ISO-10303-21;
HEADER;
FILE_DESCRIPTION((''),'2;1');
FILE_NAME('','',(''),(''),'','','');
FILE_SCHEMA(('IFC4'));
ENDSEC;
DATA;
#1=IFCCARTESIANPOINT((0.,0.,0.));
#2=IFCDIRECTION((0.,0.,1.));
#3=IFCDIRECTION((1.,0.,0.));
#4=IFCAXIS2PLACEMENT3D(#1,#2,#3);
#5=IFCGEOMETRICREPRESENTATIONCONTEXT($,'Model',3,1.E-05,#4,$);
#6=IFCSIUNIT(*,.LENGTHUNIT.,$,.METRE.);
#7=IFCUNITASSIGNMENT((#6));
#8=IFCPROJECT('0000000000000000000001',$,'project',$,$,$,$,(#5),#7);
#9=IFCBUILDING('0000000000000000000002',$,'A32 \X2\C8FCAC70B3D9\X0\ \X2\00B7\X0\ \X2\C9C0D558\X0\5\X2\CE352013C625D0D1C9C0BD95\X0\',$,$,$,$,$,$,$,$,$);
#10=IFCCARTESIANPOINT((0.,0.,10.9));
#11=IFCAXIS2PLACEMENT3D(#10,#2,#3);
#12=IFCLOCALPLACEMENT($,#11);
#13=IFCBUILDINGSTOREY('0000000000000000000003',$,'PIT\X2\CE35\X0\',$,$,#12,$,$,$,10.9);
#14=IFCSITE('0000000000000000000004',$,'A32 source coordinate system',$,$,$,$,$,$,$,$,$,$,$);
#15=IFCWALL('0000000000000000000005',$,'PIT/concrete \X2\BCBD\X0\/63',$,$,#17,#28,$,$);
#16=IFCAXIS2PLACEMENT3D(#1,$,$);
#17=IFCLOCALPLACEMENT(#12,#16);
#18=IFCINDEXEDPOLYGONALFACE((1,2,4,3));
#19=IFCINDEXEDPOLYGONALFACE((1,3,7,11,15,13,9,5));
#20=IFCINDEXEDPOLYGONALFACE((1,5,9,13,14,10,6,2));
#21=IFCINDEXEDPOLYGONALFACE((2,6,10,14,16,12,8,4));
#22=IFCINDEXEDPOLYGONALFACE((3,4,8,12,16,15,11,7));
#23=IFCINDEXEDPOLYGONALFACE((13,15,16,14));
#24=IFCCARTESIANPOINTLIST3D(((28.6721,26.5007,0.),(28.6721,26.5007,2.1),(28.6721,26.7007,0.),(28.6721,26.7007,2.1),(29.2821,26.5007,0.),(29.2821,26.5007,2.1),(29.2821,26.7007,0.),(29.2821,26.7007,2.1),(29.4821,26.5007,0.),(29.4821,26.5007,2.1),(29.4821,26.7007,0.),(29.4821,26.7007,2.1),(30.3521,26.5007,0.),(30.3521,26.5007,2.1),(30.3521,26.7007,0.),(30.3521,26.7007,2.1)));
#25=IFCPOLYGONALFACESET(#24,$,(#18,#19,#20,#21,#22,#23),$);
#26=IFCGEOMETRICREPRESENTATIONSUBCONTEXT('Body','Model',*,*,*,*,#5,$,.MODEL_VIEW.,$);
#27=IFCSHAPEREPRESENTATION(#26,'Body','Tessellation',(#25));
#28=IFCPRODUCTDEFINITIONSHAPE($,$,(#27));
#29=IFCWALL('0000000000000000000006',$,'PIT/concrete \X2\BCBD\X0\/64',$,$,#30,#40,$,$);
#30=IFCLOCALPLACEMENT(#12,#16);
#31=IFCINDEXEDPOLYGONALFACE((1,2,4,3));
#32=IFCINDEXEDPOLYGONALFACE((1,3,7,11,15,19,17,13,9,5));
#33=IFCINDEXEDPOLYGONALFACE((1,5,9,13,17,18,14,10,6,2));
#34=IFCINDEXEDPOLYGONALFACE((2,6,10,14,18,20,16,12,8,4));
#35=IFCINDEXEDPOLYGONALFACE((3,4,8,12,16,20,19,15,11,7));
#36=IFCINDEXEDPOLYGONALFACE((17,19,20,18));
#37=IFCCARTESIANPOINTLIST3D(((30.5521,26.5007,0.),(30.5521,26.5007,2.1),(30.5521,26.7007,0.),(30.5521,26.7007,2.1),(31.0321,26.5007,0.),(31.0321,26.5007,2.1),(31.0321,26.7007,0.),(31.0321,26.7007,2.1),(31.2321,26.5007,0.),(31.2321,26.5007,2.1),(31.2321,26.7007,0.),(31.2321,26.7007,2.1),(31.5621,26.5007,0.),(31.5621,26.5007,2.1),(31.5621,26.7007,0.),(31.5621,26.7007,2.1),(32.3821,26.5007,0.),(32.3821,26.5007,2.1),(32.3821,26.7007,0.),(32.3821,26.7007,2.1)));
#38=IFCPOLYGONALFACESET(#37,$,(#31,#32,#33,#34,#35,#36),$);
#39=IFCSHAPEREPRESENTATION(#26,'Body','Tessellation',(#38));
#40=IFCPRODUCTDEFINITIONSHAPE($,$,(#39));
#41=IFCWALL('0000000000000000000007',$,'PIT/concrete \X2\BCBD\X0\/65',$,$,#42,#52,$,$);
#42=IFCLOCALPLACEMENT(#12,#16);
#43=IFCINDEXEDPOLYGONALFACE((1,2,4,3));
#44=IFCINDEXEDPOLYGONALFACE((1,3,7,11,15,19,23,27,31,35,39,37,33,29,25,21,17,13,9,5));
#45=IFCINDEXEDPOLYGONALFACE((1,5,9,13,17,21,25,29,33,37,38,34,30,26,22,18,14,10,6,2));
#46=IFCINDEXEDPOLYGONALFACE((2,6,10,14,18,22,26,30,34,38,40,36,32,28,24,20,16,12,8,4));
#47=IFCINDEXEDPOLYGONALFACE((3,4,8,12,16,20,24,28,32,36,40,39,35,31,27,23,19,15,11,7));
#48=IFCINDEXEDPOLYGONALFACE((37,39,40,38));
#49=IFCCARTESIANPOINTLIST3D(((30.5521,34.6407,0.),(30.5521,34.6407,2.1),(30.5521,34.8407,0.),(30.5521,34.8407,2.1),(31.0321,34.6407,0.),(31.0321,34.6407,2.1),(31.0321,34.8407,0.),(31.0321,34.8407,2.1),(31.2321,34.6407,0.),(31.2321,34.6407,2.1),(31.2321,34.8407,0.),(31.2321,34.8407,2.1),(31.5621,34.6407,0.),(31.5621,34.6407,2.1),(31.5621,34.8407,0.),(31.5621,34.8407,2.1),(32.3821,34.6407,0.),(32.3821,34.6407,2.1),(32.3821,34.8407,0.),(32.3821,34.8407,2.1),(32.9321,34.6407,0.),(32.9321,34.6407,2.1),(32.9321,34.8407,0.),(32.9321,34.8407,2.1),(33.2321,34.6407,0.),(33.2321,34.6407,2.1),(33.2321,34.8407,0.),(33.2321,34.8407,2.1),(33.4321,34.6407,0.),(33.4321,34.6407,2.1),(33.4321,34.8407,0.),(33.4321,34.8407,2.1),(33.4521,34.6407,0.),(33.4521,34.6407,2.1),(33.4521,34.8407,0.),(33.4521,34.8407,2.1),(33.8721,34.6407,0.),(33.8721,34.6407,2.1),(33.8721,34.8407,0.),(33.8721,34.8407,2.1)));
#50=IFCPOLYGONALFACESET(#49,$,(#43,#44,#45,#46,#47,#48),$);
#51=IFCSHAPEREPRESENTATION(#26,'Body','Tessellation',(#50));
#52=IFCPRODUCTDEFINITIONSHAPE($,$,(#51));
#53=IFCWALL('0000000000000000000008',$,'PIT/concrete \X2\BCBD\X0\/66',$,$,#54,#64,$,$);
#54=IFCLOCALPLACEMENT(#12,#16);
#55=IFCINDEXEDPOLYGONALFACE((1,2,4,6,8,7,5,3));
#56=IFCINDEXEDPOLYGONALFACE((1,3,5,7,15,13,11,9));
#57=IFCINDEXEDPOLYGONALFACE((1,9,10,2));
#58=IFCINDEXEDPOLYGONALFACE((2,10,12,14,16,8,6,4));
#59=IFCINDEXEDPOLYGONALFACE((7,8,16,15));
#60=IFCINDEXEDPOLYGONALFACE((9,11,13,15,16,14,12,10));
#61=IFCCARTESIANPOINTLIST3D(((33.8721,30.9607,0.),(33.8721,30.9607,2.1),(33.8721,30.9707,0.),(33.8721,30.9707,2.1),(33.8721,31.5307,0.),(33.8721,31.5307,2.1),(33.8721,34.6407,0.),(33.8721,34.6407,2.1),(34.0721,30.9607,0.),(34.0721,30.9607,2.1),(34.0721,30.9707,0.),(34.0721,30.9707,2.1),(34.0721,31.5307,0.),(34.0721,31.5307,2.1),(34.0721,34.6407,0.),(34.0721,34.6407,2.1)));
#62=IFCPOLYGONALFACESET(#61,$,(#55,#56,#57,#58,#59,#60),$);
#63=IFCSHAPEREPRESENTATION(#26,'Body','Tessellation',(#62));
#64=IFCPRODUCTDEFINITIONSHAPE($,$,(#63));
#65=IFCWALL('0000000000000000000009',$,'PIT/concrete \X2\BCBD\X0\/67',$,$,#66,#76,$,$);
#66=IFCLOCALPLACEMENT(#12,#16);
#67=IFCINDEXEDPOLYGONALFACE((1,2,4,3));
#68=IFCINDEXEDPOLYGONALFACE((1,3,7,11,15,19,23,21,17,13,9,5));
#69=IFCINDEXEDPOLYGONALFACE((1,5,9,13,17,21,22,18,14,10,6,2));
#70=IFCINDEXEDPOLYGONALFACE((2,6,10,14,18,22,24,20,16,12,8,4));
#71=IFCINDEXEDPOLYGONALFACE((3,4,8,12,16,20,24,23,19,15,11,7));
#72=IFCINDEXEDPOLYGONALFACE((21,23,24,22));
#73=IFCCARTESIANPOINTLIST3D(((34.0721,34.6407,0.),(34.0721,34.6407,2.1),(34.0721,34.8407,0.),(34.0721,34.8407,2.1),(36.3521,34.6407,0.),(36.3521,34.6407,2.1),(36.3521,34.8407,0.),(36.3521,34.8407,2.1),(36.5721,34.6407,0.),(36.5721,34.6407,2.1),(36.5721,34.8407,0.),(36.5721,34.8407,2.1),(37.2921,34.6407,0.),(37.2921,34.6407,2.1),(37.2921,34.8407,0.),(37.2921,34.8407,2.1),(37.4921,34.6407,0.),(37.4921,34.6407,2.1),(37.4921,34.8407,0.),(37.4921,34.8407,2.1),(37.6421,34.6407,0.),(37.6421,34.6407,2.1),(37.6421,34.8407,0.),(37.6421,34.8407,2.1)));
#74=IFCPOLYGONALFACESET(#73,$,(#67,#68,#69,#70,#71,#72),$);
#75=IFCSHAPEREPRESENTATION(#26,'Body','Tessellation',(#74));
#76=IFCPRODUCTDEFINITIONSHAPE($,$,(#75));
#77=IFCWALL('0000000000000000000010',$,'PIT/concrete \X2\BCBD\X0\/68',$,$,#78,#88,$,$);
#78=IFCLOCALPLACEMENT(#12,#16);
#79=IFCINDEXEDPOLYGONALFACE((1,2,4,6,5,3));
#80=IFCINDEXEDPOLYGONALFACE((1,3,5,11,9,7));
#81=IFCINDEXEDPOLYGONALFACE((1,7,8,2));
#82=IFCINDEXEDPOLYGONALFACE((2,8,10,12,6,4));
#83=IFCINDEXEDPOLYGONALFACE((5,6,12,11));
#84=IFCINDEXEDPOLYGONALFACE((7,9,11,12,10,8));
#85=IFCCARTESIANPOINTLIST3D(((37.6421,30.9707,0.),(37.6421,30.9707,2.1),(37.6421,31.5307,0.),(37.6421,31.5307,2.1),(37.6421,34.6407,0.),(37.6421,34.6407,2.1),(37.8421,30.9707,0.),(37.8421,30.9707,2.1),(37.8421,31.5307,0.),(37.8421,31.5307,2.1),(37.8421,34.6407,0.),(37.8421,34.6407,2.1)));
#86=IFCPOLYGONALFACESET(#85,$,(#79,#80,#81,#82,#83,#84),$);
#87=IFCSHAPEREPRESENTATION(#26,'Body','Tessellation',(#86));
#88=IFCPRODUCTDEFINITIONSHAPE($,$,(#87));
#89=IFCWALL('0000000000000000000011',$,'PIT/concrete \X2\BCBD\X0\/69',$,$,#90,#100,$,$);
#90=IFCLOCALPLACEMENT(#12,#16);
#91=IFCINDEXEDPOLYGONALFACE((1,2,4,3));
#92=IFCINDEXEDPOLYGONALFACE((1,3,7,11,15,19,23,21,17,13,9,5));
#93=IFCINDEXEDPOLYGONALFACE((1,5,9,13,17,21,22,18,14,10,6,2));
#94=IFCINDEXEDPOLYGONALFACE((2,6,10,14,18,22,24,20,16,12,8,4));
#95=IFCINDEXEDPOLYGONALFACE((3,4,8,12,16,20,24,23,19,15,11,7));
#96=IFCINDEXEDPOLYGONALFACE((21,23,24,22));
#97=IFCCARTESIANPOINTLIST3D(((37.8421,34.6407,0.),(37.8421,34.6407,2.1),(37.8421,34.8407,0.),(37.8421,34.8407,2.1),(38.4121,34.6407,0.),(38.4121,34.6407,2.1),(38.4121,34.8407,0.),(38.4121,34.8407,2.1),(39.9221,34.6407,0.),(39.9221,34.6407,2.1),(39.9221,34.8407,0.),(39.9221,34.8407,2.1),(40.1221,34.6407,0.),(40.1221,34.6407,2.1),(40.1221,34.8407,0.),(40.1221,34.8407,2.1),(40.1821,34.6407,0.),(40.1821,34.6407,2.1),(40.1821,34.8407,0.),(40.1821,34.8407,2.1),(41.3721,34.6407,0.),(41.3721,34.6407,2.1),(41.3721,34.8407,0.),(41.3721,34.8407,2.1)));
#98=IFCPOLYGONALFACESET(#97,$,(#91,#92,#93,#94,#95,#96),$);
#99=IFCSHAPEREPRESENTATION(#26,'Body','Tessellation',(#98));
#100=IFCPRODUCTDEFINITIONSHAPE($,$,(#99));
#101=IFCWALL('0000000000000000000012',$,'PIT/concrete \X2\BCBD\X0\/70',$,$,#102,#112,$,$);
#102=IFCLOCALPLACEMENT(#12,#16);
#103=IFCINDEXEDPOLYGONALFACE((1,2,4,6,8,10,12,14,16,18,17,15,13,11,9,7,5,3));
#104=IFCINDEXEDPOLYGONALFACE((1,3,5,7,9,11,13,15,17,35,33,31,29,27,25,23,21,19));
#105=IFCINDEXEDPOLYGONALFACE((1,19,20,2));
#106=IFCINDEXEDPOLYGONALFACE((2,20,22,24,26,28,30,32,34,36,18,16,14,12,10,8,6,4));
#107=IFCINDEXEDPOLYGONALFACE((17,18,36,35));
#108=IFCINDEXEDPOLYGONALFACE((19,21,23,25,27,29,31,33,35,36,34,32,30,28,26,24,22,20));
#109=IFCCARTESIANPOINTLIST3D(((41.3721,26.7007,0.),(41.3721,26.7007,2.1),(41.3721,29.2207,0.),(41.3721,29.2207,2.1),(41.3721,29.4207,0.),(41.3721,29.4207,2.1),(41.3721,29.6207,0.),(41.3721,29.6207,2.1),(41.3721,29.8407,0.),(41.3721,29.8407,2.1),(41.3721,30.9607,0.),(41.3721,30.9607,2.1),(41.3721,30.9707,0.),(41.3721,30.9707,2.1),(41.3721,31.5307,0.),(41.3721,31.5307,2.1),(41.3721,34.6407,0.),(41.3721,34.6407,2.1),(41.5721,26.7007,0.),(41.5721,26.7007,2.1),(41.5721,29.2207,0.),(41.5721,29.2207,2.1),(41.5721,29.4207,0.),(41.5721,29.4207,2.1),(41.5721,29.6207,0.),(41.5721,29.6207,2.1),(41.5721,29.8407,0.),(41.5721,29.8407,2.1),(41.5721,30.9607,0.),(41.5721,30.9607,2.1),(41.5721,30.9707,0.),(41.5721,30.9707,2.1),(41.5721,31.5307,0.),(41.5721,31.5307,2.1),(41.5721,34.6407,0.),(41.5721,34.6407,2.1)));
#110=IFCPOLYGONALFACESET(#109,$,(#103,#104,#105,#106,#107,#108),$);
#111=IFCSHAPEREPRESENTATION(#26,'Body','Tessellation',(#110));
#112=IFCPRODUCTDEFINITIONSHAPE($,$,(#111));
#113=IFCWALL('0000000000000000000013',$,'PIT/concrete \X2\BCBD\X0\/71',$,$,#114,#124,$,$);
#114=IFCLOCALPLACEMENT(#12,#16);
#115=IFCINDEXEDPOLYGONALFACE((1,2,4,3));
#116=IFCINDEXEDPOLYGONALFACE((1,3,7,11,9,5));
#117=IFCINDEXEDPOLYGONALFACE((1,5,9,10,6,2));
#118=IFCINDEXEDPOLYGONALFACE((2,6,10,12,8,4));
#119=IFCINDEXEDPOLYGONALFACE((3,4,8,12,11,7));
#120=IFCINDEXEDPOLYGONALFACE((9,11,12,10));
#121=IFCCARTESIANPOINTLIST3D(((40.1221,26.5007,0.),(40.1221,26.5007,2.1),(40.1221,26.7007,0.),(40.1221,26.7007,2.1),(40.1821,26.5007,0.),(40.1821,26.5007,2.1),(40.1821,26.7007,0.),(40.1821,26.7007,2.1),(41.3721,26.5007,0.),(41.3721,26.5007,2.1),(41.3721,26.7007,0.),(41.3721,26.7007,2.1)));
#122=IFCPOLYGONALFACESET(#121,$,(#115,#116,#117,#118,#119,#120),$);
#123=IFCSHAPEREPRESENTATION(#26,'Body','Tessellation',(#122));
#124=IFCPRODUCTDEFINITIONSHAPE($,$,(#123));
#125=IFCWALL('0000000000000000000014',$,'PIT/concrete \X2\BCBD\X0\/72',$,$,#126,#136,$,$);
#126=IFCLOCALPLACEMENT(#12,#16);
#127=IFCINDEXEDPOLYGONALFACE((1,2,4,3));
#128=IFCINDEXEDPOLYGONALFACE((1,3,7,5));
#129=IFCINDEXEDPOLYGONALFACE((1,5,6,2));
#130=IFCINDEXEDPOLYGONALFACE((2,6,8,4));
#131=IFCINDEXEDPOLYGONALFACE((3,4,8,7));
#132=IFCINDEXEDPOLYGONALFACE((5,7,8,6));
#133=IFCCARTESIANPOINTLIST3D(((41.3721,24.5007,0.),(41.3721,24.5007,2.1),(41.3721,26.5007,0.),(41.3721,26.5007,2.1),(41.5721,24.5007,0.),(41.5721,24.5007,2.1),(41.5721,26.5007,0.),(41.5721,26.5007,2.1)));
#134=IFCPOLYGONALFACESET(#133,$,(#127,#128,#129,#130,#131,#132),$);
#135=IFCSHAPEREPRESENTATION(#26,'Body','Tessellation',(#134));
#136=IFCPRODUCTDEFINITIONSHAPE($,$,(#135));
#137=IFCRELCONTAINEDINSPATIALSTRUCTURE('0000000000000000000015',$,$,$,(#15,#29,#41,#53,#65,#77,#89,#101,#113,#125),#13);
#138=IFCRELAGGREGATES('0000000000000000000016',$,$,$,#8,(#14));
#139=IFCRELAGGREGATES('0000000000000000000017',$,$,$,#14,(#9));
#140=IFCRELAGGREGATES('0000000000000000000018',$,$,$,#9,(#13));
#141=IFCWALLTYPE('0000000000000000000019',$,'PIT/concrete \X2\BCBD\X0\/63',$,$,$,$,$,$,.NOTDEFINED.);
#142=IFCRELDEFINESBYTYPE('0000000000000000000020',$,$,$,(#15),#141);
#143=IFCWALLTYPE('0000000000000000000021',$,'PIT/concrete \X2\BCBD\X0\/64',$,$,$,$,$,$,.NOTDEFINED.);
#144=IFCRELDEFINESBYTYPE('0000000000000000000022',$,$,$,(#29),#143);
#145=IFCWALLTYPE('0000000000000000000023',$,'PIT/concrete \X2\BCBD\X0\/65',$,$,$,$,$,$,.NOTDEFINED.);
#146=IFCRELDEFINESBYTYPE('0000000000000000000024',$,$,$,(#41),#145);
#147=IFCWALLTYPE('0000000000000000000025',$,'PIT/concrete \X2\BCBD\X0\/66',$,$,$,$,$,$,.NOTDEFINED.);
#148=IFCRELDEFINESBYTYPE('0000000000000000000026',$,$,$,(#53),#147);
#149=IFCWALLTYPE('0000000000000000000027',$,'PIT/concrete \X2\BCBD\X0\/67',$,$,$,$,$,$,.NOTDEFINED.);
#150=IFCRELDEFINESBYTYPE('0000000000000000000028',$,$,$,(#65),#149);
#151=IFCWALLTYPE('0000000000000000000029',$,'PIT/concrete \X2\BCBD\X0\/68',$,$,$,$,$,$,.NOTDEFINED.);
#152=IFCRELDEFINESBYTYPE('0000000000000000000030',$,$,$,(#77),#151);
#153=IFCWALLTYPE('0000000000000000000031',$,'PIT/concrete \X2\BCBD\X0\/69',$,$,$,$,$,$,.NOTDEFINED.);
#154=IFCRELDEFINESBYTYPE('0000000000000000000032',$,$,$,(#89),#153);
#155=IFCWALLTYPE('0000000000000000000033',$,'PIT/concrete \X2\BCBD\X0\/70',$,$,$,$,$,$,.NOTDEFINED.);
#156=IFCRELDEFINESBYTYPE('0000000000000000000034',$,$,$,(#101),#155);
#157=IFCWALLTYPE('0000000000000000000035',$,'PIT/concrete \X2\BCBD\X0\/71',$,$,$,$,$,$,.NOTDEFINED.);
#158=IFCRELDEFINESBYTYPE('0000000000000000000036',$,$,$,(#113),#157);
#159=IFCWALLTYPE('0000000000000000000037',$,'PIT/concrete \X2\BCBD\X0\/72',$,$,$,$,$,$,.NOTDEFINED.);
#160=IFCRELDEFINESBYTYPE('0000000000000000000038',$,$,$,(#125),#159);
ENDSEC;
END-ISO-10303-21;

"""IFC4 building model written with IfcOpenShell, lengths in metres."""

from ifc_helpers import new_model, si_unit, frame, origin, origin_with_axes, place, context, subcontext, project, spatial, polyline, outline, extrude, source, transform, mapped, type_object, type_shapes, element, save


model = new_model("IFC4")

# Units and contexts
model_context = context("Model", 3, precision=1e-05, world=origin_with_axes())
body_context = subcontext(model_context, "Body", "Model", "MODEL_VIEW")
ifc_project = project(units=[si_unit("LENGTHUNIT", "METRE")], contexts=[model_context])

# Site, building, storey
site = spatial("IfcSite", under=ifc_project, Name="A32 source coordinate system")
building = spatial("IfcBuilding", under=site, Name="A32 주거동 · 지하5층–옥탑지붕")
storey_placement = place(None, frame((0.0, 0.0, 10.9), z_axis=(0.0, 0.0, 1.0), x_axis=(1.0, 0.0, 0.0)))
storey = spatial("IfcBuildingStorey", under=building, at=storey_placement, Name="PIT층", Elevation=10.9)

# Walls
wall_type_1 = type_object("IfcWallType", Name="PIT/concrete 벽/63", PredefinedType="NOTDEFINED")
shared_shape_1 = source(origin(), body_context, "Body", "SweptSolid", [
    extrude(outline(polyline([(29.2821, 26.5007), (28.6721, 26.5007), (28.6721, 26.7007), (29.2821, 26.7007), (29.4821, 26.7007), (30.3521, 26.7007), (30.3521, 26.5007), (29.4821, 26.5007), (29.2821, 26.5007)])), origin(), (0.0, 0.0, 1.0), 2.1),
])
type_shapes(wall_type_1, [shared_shape_1])
wall_1_placement = place(storey_placement, origin_with_axes())
element("IfcWall", 1, at=wall_1_placement, inside=storey, type_object=wall_type_1, Name="PIT/concrete 벽/63", context=body_context, shape_type="MappedRepresentation", body=[
    mapped(shared_shape_1, transform((0.0, 0.0, 0.0), scale=1.0)),
])
wall_type_2 = type_object("IfcWallType", Name="PIT/concrete 벽/64", PredefinedType="NOTDEFINED")
shared_shape_2 = source(origin(), body_context, "Body", "SweptSolid", [
    extrude(outline(polyline([(31.5621, 26.7007), (32.3821, 26.7007), (32.3821, 26.5007), (31.5621, 26.5007), (31.2321, 26.5007), (31.0321, 26.5007), (30.5521, 26.5007), (30.5521, 26.7007), (31.0321, 26.7007), (31.2321, 26.7007), (31.5621, 26.7007)])), origin(), (0.0, 0.0, 1.0), 2.1),
])
type_shapes(wall_type_2, [shared_shape_2])
wall_2_placement = place(storey_placement, origin_with_axes())
element("IfcWall", 2, at=wall_2_placement, inside=storey, type_object=wall_type_2, Name="PIT/concrete 벽/64", context=body_context, shape_type="MappedRepresentation", body=[
    mapped(shared_shape_2, transform((0.0, 0.0, 0.0), scale=1.0)),
])
wall_type_3 = type_object("IfcWallType", Name="PIT/concrete 벽/65", PredefinedType="NOTDEFINED")
shared_shape_3 = source(origin(), body_context, "Body", "SweptSolid", [
    extrude(outline(polyline([(31.2321, 34.8407), (31.5621, 34.8407), (32.3821, 34.8407), (32.9321, 34.8407), (33.2321, 34.8407), (33.4321, 34.8407), (33.4521, 34.8407), (33.8721, 34.8407), (33.8721, 34.6407), (33.4521, 34.6407), (33.4321, 34.6407), (33.2321, 34.6407), (32.9321, 34.6407), (32.3821, 34.6407), (31.5621, 34.6407), (31.2321, 34.6407), (31.0321, 34.6407), (30.5521, 34.6407), (30.5521, 34.8407), (31.0321, 34.8407), (31.2321, 34.8407)])), origin(), (0.0, 0.0, 1.0), 2.1),
])
type_shapes(wall_type_3, [shared_shape_3])
wall_3_placement = place(storey_placement, origin_with_axes())
element("IfcWall", 3, at=wall_3_placement, inside=storey, type_object=wall_type_3, Name="PIT/concrete 벽/65", context=body_context, shape_type="MappedRepresentation", body=[
    mapped(shared_shape_3, transform((0.0, 0.0, 0.0), scale=1.0)),
])
wall_type_4 = type_object("IfcWallType", Name="PIT/concrete 벽/66", PredefinedType="NOTDEFINED")
shared_shape_4 = source(origin(), body_context, "Body", "SweptSolid", [
    extrude(outline(polyline([(34.0721, 30.9707), (34.0721, 30.9607), (33.8721, 30.9607), (33.8721, 30.9707), (33.8721, 31.5307), (33.8721, 34.6407), (34.0721, 34.6407), (34.0721, 31.5307), (34.0721, 30.9707)])), origin(), (0.0, 0.0, 1.0), 2.1),
])
type_shapes(wall_type_4, [shared_shape_4])
wall_4_placement = place(storey_placement, origin_with_axes())
element("IfcWall", 4, at=wall_4_placement, inside=storey, type_object=wall_type_4, Name="PIT/concrete 벽/66", context=body_context, shape_type="MappedRepresentation", body=[
    mapped(shared_shape_4, transform((0.0, 0.0, 0.0), scale=1.0)),
])
wall_type_5 = type_object("IfcWallType", Name="PIT/concrete 벽/67", PredefinedType="NOTDEFINED")
shared_shape_5 = source(origin(), body_context, "Body", "SweptSolid", [
    extrude(outline(polyline([(36.5721, 34.8407), (37.2921, 34.8407), (37.4921, 34.8407), (37.6421, 34.8407), (37.6421, 34.6407), (37.4921, 34.6407), (37.2921, 34.6407), (36.5721, 34.6407), (36.3521, 34.6407), (34.0721, 34.6407), (34.0721, 34.8407), (36.3521, 34.8407), (36.5721, 34.8407)])), origin(), (0.0, 0.0, 1.0), 2.1),
])
type_shapes(wall_type_5, [shared_shape_5])
wall_5_placement = place(storey_placement, origin_with_axes())
element("IfcWall", 5, at=wall_5_placement, inside=storey, type_object=wall_type_5, Name="PIT/concrete 벽/67", context=body_context, shape_type="MappedRepresentation", body=[
    mapped(shared_shape_5, transform((0.0, 0.0, 0.0), scale=1.0)),
])
wall_type_6 = type_object("IfcWallType", Name="PIT/concrete 벽/68", PredefinedType="NOTDEFINED")
shared_shape_6 = source(origin(), body_context, "Body", "SweptSolid", [
    extrude(outline(polyline([(37.8421, 30.9707), (37.6421, 30.9707), (37.6421, 31.5307), (37.6421, 34.6407), (37.8421, 34.6407), (37.8421, 31.5307), (37.8421, 30.9707)])), origin(), (0.0, 0.0, 1.0), 2.1),
])
type_shapes(wall_type_6, [shared_shape_6])
wall_6_placement = place(storey_placement, origin_with_axes())
element("IfcWall", 6, at=wall_6_placement, inside=storey, type_object=wall_type_6, Name="PIT/concrete 벽/68", context=body_context, shape_type="MappedRepresentation", body=[
    mapped(shared_shape_6, transform((0.0, 0.0, 0.0), scale=1.0)),
])
wall_type_7 = type_object("IfcWallType", Name="PIT/concrete 벽/69", PredefinedType="NOTDEFINED")
shared_shape_7 = source(origin(), body_context, "Body", "SweptSolid", [
    extrude(outline(polyline([(39.9221, 34.8407), (40.1221, 34.8407), (40.1821, 34.8407), (41.3721, 34.8407), (41.3721, 34.6407), (40.1821, 34.6407), (40.1221, 34.6407), (39.9221, 34.6407), (38.4121, 34.6407), (37.8421, 34.6407), (37.8421, 34.8407), (38.4121, 34.8407), (39.9221, 34.8407)])), origin(), (0.0, 0.0, 1.0), 2.1),
])
type_shapes(wall_type_7, [shared_shape_7])
wall_7_placement = place(storey_placement, origin_with_axes())
element("IfcWall", 7, at=wall_7_placement, inside=storey, type_object=wall_type_7, Name="PIT/concrete 벽/69", context=body_context, shape_type="MappedRepresentation", body=[
    mapped(shared_shape_7, transform((0.0, 0.0, 0.0), scale=1.0)),
])
wall_type_8 = type_object("IfcWallType", Name="PIT/concrete 벽/70", PredefinedType="NOTDEFINED")
shared_shape_8 = source(origin(), body_context, "Body", "SweptSolid", [
    extrude(outline(polyline([(41.5721, 30.9707), (41.5721, 30.9607), (41.5721, 29.8407), (41.5721, 29.6207), (41.5721, 29.4207), (41.5721, 29.2207), (41.5721, 26.7007), (41.3721, 26.7007), (41.3721, 29.2207), (41.3721, 29.4207), (41.3721, 29.6207), (41.3721, 29.8407), (41.3721, 30.9607), (41.3721, 30.9707), (41.3721, 31.5307), (41.3721, 34.6407), (41.5721, 34.6407), (41.5721, 31.5307), (41.5721, 30.9707)])), origin(), (0.0, 0.0, 1.0), 2.1),
])
type_shapes(wall_type_8, [shared_shape_8])
wall_8_placement = place(storey_placement, origin_with_axes())
element("IfcWall", 8, at=wall_8_placement, inside=storey, type_object=wall_type_8, Name="PIT/concrete 벽/70", context=body_context, shape_type="MappedRepresentation", body=[
    mapped(shared_shape_8, transform((0.0, 0.0, 0.0), scale=1.0)),
])
wall_type_9 = type_object("IfcWallType", Name="PIT/concrete 벽/71", PredefinedType="NOTDEFINED")
shared_shape_9 = source(origin(), body_context, "Body", "SweptSolid", [
    extrude(outline(polyline([(40.1221, 26.5007), (40.1221, 26.7007), (40.1821, 26.7007), (41.3721, 26.7007), (41.3721, 26.5007), (40.1821, 26.5007), (40.1221, 26.5007)])), origin(), (0.0, 0.0, 1.0), 2.1),
])
type_shapes(wall_type_9, [shared_shape_9])
wall_9_placement = place(storey_placement, origin_with_axes())
element("IfcWall", 9, at=wall_9_placement, inside=storey, type_object=wall_type_9, Name="PIT/concrete 벽/71", context=body_context, shape_type="MappedRepresentation", body=[
    mapped(shared_shape_9, transform((0.0, 0.0, 0.0), scale=1.0)),
])
wall_type_10 = type_object("IfcWallType", Name="PIT/concrete 벽/72", PredefinedType="NOTDEFINED")
shared_shape_10 = source(origin(), body_context, "Body", "SweptSolid", [
    extrude(outline(polyline([(41.3721, 24.5007), (41.3721, 26.5007), (41.5721, 26.5007), (41.5721, 24.5007), (41.3721, 24.5007)])), origin(), (0.0, 0.0, 1.0), 2.1),
])
type_shapes(wall_type_10, [shared_shape_10])
wall_10_placement = place(storey_placement, origin_with_axes())
element("IfcWall", 10, at=wall_10_placement, inside=storey, type_object=wall_type_10, Name="PIT/concrete 벽/72", context=body_context, shape_type="MappedRepresentation", body=[
    mapped(shared_shape_10, transform((0.0, 0.0, 0.0), scale=1.0)),
])

save(model, "model.ifc")
